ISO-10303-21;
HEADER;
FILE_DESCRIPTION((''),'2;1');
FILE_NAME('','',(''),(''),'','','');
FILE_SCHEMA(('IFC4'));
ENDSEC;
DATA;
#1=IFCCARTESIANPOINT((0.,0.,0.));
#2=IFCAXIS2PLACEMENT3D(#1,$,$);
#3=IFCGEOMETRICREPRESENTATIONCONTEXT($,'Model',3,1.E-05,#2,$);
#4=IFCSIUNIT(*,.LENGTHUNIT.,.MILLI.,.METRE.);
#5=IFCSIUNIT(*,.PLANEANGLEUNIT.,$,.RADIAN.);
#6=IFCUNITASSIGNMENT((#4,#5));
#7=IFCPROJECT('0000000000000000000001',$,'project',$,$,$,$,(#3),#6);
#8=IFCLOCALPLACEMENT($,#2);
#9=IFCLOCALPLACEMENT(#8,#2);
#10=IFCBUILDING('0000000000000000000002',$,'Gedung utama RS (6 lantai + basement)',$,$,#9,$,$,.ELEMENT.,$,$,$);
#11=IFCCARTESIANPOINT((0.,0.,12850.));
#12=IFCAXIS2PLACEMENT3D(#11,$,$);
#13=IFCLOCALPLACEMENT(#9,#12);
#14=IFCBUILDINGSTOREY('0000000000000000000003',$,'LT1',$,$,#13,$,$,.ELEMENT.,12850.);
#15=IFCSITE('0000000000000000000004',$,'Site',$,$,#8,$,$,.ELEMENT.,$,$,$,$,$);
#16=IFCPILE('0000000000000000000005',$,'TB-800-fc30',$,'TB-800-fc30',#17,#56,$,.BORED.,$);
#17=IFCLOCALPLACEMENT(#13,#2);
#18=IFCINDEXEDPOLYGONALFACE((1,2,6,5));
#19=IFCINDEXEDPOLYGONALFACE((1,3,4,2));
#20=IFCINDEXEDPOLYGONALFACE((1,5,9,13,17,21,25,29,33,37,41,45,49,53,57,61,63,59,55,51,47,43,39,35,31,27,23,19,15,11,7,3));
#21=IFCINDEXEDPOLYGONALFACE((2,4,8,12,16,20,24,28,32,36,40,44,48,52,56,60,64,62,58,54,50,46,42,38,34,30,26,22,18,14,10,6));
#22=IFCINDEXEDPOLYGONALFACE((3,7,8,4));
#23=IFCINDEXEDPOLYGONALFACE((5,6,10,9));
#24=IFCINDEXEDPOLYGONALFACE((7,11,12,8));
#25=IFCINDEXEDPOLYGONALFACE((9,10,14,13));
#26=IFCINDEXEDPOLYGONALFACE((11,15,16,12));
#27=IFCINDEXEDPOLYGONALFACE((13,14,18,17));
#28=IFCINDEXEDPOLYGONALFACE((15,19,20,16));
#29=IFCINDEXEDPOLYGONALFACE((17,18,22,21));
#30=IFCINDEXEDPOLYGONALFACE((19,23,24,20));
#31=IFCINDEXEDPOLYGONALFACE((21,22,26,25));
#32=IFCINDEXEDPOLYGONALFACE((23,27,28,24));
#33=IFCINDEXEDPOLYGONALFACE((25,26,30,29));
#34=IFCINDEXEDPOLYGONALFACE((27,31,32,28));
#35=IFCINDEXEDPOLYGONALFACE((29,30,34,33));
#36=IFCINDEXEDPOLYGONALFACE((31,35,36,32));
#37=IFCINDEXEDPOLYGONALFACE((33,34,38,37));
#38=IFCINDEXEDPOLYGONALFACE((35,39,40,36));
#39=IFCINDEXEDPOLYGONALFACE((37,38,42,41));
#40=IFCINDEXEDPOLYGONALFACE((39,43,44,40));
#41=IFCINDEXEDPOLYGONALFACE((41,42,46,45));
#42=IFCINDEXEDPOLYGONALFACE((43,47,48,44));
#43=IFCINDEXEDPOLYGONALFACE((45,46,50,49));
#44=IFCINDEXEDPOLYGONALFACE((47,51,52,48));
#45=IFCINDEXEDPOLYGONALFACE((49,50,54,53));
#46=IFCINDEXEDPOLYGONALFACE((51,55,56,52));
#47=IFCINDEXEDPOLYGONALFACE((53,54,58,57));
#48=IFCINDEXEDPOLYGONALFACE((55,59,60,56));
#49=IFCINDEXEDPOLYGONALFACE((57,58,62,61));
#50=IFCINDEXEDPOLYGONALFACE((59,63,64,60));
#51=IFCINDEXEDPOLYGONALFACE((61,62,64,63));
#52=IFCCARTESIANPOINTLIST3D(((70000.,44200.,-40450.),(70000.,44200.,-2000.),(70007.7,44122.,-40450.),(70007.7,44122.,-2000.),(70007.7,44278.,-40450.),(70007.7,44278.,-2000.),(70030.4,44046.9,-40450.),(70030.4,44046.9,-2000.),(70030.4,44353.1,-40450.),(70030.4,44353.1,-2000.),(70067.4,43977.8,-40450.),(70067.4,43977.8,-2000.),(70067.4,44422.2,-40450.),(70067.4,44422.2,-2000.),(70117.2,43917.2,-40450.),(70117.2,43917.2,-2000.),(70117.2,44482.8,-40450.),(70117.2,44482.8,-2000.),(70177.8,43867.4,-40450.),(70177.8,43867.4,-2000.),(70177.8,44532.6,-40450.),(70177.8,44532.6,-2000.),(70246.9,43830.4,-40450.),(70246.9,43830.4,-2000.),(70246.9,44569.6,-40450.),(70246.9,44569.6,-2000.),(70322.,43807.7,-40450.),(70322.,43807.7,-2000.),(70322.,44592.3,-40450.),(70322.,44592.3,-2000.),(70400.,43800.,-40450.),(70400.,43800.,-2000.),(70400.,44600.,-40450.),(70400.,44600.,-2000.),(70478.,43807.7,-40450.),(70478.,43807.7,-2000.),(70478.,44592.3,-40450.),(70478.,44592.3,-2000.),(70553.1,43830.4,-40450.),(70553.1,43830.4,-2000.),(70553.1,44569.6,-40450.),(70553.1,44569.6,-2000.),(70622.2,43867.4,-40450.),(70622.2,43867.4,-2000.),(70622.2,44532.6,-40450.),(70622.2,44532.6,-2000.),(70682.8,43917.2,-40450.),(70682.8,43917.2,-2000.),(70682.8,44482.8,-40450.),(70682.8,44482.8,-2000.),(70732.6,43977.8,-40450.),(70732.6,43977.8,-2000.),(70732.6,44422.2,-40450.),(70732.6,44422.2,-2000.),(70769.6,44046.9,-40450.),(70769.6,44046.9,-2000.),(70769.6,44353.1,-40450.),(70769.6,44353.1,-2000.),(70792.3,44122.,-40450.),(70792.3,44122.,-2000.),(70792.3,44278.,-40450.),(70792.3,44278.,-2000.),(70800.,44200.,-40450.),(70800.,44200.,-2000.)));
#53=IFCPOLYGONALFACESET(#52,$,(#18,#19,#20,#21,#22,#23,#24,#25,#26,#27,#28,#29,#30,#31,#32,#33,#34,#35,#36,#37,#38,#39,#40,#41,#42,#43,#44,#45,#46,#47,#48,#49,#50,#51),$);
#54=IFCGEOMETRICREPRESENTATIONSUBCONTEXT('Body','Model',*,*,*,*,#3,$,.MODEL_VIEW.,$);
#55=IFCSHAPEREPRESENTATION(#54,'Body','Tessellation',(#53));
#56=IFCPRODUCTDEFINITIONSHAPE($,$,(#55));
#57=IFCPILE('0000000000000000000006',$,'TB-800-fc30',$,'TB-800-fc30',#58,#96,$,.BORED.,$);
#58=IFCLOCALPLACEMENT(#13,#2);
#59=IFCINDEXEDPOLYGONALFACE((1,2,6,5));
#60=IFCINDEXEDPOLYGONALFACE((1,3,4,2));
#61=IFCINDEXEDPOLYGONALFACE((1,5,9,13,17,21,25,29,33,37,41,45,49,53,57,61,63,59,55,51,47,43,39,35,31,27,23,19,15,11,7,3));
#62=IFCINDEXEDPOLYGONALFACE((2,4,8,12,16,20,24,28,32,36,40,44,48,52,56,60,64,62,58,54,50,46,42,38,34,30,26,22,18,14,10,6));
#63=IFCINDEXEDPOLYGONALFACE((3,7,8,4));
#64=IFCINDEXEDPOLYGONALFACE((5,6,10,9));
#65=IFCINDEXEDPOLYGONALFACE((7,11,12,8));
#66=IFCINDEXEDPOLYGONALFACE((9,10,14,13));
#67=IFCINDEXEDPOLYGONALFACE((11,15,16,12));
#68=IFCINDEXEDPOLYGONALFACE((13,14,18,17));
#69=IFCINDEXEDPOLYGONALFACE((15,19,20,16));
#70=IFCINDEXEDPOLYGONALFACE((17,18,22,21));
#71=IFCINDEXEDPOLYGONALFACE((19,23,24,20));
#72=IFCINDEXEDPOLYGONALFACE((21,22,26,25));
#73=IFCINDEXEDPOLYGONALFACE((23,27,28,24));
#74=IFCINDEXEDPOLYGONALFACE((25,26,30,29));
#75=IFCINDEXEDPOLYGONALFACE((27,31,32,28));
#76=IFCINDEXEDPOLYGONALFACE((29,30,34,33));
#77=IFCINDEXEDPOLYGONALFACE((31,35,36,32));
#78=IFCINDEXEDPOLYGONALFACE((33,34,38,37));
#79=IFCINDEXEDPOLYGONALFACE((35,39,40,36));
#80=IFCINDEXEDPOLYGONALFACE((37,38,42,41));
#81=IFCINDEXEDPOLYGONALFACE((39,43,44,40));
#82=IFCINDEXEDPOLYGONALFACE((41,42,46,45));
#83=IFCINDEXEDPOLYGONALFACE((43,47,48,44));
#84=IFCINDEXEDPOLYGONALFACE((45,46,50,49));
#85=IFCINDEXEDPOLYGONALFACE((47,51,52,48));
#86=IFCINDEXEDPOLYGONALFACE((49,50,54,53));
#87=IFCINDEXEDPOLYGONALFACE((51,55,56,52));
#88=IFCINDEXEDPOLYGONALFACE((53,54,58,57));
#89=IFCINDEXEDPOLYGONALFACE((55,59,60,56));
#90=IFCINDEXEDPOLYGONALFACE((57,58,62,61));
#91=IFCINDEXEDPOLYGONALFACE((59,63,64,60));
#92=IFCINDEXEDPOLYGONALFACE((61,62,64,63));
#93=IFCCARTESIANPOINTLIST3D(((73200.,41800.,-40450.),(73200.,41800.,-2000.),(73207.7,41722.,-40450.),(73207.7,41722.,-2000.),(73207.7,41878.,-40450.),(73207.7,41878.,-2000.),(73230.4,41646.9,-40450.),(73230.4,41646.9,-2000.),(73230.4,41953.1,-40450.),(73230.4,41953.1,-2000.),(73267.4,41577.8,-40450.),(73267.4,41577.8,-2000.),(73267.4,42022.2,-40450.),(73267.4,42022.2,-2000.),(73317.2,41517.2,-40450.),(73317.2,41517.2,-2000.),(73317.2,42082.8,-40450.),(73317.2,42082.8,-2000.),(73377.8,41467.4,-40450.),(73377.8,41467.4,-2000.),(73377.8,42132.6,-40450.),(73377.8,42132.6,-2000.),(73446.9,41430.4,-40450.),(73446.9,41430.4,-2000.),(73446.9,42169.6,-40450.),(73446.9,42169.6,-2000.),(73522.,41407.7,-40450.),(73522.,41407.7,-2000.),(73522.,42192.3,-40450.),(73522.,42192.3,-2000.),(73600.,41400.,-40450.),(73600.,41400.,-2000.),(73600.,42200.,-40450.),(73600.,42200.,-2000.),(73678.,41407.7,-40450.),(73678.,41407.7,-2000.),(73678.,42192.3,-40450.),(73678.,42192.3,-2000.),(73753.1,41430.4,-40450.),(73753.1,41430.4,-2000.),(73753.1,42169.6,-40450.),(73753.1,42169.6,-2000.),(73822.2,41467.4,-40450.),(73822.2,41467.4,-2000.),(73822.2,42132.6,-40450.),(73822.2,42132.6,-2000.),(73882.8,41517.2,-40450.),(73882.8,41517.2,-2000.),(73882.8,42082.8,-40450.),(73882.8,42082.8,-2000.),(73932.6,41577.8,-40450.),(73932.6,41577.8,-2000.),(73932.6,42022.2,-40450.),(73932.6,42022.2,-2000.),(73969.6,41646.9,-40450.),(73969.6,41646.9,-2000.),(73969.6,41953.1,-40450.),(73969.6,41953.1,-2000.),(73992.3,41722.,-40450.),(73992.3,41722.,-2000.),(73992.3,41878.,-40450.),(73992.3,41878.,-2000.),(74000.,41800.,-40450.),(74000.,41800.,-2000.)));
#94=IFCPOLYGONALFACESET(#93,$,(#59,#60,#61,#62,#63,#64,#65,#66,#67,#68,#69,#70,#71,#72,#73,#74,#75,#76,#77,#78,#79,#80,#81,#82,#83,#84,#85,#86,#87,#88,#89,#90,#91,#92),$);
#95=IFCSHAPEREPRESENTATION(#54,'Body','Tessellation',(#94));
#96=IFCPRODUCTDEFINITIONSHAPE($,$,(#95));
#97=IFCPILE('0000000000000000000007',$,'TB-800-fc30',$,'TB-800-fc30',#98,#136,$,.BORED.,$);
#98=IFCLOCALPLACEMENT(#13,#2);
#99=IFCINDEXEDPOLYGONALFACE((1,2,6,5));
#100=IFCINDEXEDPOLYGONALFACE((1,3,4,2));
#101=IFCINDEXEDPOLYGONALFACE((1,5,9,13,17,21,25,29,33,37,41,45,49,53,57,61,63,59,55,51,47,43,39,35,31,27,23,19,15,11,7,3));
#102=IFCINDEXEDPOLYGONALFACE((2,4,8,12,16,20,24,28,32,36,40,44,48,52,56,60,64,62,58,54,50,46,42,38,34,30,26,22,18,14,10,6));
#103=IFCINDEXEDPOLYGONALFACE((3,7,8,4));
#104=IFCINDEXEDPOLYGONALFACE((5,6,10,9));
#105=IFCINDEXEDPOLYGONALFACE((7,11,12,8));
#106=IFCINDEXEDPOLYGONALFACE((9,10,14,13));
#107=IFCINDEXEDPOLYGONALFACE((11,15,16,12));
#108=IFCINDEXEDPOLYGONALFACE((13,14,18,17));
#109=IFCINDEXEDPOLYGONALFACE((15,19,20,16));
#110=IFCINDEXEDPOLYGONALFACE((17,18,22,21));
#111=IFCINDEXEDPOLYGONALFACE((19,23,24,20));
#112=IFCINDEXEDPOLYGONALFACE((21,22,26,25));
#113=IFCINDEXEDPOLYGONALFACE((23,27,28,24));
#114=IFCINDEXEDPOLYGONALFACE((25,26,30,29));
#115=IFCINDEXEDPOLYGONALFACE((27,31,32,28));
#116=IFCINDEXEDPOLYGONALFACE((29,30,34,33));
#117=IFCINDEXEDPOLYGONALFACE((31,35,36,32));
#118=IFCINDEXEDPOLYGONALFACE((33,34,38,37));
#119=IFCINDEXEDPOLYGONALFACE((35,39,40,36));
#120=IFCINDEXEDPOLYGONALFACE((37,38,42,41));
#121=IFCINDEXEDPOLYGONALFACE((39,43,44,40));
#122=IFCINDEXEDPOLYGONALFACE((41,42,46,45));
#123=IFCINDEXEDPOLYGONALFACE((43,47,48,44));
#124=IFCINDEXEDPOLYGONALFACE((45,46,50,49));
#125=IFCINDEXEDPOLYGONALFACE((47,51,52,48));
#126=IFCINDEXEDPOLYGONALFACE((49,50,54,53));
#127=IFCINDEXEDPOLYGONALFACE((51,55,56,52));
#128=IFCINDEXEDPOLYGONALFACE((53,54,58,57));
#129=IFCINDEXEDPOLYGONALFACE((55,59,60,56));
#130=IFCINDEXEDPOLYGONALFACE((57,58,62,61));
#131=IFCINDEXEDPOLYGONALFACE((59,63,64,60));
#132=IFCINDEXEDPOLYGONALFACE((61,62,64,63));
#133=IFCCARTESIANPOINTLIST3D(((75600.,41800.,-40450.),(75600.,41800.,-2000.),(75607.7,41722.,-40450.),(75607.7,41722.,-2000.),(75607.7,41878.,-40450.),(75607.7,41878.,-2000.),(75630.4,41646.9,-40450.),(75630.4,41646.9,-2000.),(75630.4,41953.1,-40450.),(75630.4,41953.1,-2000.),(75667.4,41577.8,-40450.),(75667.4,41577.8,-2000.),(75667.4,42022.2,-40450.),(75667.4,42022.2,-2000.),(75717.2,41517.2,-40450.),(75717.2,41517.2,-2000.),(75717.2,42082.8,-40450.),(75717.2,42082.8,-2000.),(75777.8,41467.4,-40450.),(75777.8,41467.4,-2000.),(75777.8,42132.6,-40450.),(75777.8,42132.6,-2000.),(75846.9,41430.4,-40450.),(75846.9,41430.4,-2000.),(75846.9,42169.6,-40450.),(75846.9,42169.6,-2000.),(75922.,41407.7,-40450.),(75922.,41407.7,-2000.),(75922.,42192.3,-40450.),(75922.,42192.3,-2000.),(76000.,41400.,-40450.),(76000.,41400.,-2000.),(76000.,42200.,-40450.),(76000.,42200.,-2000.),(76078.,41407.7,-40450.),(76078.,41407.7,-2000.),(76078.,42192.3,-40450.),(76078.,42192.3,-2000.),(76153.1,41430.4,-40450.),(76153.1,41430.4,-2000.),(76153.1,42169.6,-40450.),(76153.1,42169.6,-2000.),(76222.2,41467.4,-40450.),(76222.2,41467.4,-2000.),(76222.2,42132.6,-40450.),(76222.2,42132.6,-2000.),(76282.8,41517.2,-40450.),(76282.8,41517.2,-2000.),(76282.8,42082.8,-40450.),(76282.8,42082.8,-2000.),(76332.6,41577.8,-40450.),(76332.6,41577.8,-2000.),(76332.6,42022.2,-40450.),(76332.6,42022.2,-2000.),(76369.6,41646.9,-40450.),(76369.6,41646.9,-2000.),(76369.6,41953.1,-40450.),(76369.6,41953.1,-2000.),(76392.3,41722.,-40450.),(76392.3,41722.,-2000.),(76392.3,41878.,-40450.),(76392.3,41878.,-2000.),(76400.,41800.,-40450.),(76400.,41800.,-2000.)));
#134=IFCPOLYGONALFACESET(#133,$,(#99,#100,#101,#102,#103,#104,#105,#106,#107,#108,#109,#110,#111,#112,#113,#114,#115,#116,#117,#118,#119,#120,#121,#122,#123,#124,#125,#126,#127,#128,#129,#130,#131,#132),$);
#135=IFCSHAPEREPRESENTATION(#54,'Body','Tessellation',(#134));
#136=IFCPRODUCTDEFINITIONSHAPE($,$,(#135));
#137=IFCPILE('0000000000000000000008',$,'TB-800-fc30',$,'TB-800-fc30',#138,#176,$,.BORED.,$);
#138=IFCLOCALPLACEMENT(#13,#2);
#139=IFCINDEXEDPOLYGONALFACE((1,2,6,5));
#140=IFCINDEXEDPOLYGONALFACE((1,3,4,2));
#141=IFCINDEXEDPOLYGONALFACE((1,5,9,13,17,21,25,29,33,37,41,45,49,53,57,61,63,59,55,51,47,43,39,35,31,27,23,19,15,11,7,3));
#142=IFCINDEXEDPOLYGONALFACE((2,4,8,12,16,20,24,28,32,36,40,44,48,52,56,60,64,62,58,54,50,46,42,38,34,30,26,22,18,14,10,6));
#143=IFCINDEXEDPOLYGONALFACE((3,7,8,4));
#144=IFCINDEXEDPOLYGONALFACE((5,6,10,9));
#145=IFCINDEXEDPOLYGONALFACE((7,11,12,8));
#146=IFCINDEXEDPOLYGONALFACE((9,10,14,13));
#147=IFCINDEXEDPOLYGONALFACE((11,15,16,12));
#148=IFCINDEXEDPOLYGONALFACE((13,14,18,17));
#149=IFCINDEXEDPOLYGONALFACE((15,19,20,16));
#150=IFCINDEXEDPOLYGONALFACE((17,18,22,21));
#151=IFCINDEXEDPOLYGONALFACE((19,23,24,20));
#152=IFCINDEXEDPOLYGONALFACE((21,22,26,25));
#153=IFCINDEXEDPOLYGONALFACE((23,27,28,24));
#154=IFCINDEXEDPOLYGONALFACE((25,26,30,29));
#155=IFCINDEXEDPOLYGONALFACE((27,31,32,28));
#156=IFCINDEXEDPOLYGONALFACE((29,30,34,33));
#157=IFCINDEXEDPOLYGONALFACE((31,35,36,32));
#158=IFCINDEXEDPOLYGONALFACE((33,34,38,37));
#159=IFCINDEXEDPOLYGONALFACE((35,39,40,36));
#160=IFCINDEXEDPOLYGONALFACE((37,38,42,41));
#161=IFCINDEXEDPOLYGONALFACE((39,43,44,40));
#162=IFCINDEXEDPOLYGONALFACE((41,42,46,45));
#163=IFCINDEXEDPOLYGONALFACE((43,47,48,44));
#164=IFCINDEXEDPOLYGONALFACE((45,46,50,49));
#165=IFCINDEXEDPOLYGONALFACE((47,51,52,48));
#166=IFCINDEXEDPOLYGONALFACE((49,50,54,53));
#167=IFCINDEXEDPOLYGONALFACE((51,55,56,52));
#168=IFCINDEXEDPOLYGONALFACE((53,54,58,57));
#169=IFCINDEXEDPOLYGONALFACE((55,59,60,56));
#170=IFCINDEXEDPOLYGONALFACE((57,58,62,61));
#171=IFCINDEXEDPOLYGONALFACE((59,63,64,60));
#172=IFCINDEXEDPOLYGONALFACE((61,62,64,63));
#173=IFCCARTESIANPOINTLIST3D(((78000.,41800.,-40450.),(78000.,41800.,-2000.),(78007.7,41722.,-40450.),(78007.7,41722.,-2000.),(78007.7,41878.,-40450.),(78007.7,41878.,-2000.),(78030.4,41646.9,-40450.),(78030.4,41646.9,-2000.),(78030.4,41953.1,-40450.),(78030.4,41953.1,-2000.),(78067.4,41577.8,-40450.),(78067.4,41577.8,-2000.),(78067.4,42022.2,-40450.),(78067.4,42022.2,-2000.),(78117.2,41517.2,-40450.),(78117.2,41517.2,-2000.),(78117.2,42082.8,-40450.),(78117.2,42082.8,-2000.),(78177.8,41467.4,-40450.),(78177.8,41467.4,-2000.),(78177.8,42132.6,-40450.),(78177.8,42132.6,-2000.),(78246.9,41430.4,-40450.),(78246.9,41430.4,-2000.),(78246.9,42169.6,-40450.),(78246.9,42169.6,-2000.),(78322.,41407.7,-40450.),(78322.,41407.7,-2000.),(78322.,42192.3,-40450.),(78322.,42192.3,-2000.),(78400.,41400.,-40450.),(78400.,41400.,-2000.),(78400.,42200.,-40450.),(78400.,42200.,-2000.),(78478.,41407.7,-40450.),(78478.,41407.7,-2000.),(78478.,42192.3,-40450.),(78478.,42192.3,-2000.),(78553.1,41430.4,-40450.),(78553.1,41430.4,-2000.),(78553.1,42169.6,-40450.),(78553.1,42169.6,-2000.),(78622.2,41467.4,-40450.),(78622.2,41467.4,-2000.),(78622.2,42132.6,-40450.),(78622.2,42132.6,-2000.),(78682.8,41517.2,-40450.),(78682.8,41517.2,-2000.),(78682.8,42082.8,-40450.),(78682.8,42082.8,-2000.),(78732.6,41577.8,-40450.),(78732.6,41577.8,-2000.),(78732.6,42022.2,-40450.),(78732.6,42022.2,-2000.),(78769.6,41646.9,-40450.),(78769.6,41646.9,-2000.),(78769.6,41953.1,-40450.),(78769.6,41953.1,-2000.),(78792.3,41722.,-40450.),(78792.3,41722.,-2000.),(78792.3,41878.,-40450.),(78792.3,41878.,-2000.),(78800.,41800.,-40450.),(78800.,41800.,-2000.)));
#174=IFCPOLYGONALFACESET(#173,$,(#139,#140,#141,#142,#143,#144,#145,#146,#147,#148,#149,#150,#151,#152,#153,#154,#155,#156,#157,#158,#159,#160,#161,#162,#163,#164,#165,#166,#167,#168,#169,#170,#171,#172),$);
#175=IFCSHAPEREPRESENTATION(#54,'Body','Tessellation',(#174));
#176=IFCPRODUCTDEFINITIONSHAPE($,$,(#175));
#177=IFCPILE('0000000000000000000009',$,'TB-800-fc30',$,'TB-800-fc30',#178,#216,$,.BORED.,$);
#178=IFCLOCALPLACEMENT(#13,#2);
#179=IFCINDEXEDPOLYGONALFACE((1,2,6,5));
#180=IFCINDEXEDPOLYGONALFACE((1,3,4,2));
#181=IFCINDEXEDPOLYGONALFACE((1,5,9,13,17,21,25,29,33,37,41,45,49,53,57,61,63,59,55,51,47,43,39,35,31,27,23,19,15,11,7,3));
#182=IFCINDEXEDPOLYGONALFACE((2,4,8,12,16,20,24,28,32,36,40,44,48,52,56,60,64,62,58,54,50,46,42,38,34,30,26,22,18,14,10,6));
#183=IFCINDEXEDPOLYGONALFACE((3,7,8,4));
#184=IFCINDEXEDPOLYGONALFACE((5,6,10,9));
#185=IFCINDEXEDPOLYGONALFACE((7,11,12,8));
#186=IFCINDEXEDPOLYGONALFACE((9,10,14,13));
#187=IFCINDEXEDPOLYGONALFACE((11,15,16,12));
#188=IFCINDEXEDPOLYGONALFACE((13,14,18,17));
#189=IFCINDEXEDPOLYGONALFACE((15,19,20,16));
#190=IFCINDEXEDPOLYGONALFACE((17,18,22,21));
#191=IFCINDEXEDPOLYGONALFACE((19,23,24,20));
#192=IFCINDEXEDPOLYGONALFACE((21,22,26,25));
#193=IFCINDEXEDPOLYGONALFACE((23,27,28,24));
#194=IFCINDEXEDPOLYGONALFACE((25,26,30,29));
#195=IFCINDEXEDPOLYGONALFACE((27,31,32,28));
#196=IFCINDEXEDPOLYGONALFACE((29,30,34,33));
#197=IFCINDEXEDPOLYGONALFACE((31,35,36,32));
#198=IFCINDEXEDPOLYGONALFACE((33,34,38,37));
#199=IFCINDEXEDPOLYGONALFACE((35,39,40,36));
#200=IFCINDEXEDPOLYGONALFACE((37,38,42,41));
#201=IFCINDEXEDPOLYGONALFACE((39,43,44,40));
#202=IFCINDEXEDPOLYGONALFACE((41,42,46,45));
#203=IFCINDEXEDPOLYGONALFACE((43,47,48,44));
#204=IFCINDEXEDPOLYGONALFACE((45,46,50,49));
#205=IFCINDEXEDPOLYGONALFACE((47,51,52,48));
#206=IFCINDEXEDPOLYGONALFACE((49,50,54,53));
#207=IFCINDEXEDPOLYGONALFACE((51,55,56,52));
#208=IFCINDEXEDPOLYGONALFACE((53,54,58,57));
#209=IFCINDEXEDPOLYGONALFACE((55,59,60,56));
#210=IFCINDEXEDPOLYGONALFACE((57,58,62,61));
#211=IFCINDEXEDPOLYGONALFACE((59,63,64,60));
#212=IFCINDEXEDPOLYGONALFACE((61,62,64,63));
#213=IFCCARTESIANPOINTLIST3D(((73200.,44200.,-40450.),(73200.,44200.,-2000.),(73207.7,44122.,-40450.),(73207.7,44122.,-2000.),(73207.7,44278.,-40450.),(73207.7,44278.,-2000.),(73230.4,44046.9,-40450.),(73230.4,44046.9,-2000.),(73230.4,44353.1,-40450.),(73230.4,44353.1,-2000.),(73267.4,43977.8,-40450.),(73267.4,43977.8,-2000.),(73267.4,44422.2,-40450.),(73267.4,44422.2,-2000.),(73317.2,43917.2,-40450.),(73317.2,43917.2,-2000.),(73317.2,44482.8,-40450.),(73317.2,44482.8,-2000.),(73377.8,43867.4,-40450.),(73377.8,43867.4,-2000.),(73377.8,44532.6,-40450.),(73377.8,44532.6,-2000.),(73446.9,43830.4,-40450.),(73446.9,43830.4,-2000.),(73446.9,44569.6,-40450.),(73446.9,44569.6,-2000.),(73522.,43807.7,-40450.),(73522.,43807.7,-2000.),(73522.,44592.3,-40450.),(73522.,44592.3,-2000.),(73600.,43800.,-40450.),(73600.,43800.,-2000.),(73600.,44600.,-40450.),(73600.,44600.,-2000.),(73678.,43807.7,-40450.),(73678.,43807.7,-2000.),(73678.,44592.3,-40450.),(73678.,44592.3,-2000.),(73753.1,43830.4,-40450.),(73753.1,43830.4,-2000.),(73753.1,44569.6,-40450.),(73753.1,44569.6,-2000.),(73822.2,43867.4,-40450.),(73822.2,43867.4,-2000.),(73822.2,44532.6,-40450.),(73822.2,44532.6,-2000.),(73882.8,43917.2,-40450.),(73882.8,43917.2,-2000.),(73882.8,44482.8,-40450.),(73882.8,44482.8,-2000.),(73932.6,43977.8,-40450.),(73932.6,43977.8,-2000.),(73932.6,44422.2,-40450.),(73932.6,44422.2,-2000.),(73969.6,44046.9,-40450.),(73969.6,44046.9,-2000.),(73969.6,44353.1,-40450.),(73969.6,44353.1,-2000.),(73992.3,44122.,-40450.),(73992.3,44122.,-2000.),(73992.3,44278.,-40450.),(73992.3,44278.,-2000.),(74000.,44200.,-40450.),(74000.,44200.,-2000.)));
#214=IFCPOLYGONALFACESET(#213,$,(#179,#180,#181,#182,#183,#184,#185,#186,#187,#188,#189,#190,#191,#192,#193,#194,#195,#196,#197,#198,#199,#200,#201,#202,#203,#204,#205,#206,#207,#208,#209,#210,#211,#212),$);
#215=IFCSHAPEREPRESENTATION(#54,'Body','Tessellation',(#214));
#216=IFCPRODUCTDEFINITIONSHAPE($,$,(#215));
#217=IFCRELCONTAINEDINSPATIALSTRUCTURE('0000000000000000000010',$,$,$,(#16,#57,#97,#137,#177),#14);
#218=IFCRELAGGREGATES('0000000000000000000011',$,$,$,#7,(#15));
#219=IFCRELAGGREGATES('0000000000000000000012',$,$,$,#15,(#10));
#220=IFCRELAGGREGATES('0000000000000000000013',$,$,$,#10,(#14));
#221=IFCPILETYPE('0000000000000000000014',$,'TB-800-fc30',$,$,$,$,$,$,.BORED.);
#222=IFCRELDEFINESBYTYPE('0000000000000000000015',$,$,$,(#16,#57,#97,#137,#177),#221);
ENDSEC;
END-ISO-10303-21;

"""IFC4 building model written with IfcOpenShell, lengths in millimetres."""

from ifc_helpers import new_model, si_unit, frame, origin, origin_2d, place, context, subcontext, project, spatial, circle, extrude, material_profile, profile_set, profile_usage, type_object, element, save


model = new_model("IFC4")

# Units and contexts
model_context = context("Model", 3, precision=1e-05, world=origin())
body_context = subcontext(model_context, "Body", "Model", "MODEL_VIEW")
ifc_project = project(units=[si_unit("LENGTHUNIT", "METRE", prefix="MILLI"), si_unit("PLANEANGLEUNIT", "RADIAN")], contexts=[model_context])

# Site, building, storey
site_placement = place(None, origin())
site = spatial("IfcSite", under=ifc_project, at=site_placement, Name="Site", CompositionType="ELEMENT")
building_placement = place(site_placement, origin())
building = spatial("IfcBuilding", under=site, at=building_placement, Name="Gedung utama RS (6 lantai + basement)", CompositionType="ELEMENT")
storey_placement = place(building_placement, frame((0.0, 0.0, 12850.0)))
storey = spatial("IfcBuildingStorey", under=building, at=storey_placement, Name="LT1", CompositionType="ELEMENT", Elevation=12850.0)

# Piles
ifc_material_profile_1 = material_profile(None, circle(Radius=400.0, at=origin_2d()), Name="TB-800-fc30")
ifc_profile_set_1 = profile_set([ifc_material_profile_1], Name="TB-800-fc30")
ifc_profile_usage_1 = profile_usage(ifc_profile_set_1, cardinal=5)
pile_type = type_object("IfcPileType", Name="TB-800-fc30", PredefinedType="BORED", material=ifc_profile_set_1)
for number, where, z_axis, x_axis, name in (
    (1, (70400.0, 44200.0, -40450.0), (0.0, 0.0, 1.0), (1.0, 0.0, 0.0), "TB-800-fc30"),
    (2, (73600.0, 41800.0, -40450.0), (0.0, 0.0, 1.0), (1.0, 0.0, 0.0), "TB-800-fc30"),
    (3, (76000.0, 41800.0, -40450.0), (0.0, 0.0, 1.0), (1.0, 0.0, 0.0), "TB-800-fc30"),
    (4, (78400.0, 41800.0, -40450.0), (0.0, 0.0, 1.0), (1.0, 0.0, 0.0), "TB-800-fc30"),
    (5, (73600.0, 44200.0, -40450.0), (0.0, 0.0, 1.0), (1.0, 0.0, 0.0), "TB-800-fc30"),
):
    element("IfcPile", number, at=place(storey_placement, frame(where, z_axis=z_axis, x_axis=x_axis)), inside=storey, type_object=pile_type, material=ifc_profile_usage_1, Name=name, ObjectType="TB-800-fc30", PredefinedType="BORED", context=body_context, shape_type="SweptSolid", body=[
        extrude(circle(Radius=400.0, at=origin_2d()), origin(), (0.0, 0.0, 1.0), 38450.0),
    ])

save(model, "model.ifc")
